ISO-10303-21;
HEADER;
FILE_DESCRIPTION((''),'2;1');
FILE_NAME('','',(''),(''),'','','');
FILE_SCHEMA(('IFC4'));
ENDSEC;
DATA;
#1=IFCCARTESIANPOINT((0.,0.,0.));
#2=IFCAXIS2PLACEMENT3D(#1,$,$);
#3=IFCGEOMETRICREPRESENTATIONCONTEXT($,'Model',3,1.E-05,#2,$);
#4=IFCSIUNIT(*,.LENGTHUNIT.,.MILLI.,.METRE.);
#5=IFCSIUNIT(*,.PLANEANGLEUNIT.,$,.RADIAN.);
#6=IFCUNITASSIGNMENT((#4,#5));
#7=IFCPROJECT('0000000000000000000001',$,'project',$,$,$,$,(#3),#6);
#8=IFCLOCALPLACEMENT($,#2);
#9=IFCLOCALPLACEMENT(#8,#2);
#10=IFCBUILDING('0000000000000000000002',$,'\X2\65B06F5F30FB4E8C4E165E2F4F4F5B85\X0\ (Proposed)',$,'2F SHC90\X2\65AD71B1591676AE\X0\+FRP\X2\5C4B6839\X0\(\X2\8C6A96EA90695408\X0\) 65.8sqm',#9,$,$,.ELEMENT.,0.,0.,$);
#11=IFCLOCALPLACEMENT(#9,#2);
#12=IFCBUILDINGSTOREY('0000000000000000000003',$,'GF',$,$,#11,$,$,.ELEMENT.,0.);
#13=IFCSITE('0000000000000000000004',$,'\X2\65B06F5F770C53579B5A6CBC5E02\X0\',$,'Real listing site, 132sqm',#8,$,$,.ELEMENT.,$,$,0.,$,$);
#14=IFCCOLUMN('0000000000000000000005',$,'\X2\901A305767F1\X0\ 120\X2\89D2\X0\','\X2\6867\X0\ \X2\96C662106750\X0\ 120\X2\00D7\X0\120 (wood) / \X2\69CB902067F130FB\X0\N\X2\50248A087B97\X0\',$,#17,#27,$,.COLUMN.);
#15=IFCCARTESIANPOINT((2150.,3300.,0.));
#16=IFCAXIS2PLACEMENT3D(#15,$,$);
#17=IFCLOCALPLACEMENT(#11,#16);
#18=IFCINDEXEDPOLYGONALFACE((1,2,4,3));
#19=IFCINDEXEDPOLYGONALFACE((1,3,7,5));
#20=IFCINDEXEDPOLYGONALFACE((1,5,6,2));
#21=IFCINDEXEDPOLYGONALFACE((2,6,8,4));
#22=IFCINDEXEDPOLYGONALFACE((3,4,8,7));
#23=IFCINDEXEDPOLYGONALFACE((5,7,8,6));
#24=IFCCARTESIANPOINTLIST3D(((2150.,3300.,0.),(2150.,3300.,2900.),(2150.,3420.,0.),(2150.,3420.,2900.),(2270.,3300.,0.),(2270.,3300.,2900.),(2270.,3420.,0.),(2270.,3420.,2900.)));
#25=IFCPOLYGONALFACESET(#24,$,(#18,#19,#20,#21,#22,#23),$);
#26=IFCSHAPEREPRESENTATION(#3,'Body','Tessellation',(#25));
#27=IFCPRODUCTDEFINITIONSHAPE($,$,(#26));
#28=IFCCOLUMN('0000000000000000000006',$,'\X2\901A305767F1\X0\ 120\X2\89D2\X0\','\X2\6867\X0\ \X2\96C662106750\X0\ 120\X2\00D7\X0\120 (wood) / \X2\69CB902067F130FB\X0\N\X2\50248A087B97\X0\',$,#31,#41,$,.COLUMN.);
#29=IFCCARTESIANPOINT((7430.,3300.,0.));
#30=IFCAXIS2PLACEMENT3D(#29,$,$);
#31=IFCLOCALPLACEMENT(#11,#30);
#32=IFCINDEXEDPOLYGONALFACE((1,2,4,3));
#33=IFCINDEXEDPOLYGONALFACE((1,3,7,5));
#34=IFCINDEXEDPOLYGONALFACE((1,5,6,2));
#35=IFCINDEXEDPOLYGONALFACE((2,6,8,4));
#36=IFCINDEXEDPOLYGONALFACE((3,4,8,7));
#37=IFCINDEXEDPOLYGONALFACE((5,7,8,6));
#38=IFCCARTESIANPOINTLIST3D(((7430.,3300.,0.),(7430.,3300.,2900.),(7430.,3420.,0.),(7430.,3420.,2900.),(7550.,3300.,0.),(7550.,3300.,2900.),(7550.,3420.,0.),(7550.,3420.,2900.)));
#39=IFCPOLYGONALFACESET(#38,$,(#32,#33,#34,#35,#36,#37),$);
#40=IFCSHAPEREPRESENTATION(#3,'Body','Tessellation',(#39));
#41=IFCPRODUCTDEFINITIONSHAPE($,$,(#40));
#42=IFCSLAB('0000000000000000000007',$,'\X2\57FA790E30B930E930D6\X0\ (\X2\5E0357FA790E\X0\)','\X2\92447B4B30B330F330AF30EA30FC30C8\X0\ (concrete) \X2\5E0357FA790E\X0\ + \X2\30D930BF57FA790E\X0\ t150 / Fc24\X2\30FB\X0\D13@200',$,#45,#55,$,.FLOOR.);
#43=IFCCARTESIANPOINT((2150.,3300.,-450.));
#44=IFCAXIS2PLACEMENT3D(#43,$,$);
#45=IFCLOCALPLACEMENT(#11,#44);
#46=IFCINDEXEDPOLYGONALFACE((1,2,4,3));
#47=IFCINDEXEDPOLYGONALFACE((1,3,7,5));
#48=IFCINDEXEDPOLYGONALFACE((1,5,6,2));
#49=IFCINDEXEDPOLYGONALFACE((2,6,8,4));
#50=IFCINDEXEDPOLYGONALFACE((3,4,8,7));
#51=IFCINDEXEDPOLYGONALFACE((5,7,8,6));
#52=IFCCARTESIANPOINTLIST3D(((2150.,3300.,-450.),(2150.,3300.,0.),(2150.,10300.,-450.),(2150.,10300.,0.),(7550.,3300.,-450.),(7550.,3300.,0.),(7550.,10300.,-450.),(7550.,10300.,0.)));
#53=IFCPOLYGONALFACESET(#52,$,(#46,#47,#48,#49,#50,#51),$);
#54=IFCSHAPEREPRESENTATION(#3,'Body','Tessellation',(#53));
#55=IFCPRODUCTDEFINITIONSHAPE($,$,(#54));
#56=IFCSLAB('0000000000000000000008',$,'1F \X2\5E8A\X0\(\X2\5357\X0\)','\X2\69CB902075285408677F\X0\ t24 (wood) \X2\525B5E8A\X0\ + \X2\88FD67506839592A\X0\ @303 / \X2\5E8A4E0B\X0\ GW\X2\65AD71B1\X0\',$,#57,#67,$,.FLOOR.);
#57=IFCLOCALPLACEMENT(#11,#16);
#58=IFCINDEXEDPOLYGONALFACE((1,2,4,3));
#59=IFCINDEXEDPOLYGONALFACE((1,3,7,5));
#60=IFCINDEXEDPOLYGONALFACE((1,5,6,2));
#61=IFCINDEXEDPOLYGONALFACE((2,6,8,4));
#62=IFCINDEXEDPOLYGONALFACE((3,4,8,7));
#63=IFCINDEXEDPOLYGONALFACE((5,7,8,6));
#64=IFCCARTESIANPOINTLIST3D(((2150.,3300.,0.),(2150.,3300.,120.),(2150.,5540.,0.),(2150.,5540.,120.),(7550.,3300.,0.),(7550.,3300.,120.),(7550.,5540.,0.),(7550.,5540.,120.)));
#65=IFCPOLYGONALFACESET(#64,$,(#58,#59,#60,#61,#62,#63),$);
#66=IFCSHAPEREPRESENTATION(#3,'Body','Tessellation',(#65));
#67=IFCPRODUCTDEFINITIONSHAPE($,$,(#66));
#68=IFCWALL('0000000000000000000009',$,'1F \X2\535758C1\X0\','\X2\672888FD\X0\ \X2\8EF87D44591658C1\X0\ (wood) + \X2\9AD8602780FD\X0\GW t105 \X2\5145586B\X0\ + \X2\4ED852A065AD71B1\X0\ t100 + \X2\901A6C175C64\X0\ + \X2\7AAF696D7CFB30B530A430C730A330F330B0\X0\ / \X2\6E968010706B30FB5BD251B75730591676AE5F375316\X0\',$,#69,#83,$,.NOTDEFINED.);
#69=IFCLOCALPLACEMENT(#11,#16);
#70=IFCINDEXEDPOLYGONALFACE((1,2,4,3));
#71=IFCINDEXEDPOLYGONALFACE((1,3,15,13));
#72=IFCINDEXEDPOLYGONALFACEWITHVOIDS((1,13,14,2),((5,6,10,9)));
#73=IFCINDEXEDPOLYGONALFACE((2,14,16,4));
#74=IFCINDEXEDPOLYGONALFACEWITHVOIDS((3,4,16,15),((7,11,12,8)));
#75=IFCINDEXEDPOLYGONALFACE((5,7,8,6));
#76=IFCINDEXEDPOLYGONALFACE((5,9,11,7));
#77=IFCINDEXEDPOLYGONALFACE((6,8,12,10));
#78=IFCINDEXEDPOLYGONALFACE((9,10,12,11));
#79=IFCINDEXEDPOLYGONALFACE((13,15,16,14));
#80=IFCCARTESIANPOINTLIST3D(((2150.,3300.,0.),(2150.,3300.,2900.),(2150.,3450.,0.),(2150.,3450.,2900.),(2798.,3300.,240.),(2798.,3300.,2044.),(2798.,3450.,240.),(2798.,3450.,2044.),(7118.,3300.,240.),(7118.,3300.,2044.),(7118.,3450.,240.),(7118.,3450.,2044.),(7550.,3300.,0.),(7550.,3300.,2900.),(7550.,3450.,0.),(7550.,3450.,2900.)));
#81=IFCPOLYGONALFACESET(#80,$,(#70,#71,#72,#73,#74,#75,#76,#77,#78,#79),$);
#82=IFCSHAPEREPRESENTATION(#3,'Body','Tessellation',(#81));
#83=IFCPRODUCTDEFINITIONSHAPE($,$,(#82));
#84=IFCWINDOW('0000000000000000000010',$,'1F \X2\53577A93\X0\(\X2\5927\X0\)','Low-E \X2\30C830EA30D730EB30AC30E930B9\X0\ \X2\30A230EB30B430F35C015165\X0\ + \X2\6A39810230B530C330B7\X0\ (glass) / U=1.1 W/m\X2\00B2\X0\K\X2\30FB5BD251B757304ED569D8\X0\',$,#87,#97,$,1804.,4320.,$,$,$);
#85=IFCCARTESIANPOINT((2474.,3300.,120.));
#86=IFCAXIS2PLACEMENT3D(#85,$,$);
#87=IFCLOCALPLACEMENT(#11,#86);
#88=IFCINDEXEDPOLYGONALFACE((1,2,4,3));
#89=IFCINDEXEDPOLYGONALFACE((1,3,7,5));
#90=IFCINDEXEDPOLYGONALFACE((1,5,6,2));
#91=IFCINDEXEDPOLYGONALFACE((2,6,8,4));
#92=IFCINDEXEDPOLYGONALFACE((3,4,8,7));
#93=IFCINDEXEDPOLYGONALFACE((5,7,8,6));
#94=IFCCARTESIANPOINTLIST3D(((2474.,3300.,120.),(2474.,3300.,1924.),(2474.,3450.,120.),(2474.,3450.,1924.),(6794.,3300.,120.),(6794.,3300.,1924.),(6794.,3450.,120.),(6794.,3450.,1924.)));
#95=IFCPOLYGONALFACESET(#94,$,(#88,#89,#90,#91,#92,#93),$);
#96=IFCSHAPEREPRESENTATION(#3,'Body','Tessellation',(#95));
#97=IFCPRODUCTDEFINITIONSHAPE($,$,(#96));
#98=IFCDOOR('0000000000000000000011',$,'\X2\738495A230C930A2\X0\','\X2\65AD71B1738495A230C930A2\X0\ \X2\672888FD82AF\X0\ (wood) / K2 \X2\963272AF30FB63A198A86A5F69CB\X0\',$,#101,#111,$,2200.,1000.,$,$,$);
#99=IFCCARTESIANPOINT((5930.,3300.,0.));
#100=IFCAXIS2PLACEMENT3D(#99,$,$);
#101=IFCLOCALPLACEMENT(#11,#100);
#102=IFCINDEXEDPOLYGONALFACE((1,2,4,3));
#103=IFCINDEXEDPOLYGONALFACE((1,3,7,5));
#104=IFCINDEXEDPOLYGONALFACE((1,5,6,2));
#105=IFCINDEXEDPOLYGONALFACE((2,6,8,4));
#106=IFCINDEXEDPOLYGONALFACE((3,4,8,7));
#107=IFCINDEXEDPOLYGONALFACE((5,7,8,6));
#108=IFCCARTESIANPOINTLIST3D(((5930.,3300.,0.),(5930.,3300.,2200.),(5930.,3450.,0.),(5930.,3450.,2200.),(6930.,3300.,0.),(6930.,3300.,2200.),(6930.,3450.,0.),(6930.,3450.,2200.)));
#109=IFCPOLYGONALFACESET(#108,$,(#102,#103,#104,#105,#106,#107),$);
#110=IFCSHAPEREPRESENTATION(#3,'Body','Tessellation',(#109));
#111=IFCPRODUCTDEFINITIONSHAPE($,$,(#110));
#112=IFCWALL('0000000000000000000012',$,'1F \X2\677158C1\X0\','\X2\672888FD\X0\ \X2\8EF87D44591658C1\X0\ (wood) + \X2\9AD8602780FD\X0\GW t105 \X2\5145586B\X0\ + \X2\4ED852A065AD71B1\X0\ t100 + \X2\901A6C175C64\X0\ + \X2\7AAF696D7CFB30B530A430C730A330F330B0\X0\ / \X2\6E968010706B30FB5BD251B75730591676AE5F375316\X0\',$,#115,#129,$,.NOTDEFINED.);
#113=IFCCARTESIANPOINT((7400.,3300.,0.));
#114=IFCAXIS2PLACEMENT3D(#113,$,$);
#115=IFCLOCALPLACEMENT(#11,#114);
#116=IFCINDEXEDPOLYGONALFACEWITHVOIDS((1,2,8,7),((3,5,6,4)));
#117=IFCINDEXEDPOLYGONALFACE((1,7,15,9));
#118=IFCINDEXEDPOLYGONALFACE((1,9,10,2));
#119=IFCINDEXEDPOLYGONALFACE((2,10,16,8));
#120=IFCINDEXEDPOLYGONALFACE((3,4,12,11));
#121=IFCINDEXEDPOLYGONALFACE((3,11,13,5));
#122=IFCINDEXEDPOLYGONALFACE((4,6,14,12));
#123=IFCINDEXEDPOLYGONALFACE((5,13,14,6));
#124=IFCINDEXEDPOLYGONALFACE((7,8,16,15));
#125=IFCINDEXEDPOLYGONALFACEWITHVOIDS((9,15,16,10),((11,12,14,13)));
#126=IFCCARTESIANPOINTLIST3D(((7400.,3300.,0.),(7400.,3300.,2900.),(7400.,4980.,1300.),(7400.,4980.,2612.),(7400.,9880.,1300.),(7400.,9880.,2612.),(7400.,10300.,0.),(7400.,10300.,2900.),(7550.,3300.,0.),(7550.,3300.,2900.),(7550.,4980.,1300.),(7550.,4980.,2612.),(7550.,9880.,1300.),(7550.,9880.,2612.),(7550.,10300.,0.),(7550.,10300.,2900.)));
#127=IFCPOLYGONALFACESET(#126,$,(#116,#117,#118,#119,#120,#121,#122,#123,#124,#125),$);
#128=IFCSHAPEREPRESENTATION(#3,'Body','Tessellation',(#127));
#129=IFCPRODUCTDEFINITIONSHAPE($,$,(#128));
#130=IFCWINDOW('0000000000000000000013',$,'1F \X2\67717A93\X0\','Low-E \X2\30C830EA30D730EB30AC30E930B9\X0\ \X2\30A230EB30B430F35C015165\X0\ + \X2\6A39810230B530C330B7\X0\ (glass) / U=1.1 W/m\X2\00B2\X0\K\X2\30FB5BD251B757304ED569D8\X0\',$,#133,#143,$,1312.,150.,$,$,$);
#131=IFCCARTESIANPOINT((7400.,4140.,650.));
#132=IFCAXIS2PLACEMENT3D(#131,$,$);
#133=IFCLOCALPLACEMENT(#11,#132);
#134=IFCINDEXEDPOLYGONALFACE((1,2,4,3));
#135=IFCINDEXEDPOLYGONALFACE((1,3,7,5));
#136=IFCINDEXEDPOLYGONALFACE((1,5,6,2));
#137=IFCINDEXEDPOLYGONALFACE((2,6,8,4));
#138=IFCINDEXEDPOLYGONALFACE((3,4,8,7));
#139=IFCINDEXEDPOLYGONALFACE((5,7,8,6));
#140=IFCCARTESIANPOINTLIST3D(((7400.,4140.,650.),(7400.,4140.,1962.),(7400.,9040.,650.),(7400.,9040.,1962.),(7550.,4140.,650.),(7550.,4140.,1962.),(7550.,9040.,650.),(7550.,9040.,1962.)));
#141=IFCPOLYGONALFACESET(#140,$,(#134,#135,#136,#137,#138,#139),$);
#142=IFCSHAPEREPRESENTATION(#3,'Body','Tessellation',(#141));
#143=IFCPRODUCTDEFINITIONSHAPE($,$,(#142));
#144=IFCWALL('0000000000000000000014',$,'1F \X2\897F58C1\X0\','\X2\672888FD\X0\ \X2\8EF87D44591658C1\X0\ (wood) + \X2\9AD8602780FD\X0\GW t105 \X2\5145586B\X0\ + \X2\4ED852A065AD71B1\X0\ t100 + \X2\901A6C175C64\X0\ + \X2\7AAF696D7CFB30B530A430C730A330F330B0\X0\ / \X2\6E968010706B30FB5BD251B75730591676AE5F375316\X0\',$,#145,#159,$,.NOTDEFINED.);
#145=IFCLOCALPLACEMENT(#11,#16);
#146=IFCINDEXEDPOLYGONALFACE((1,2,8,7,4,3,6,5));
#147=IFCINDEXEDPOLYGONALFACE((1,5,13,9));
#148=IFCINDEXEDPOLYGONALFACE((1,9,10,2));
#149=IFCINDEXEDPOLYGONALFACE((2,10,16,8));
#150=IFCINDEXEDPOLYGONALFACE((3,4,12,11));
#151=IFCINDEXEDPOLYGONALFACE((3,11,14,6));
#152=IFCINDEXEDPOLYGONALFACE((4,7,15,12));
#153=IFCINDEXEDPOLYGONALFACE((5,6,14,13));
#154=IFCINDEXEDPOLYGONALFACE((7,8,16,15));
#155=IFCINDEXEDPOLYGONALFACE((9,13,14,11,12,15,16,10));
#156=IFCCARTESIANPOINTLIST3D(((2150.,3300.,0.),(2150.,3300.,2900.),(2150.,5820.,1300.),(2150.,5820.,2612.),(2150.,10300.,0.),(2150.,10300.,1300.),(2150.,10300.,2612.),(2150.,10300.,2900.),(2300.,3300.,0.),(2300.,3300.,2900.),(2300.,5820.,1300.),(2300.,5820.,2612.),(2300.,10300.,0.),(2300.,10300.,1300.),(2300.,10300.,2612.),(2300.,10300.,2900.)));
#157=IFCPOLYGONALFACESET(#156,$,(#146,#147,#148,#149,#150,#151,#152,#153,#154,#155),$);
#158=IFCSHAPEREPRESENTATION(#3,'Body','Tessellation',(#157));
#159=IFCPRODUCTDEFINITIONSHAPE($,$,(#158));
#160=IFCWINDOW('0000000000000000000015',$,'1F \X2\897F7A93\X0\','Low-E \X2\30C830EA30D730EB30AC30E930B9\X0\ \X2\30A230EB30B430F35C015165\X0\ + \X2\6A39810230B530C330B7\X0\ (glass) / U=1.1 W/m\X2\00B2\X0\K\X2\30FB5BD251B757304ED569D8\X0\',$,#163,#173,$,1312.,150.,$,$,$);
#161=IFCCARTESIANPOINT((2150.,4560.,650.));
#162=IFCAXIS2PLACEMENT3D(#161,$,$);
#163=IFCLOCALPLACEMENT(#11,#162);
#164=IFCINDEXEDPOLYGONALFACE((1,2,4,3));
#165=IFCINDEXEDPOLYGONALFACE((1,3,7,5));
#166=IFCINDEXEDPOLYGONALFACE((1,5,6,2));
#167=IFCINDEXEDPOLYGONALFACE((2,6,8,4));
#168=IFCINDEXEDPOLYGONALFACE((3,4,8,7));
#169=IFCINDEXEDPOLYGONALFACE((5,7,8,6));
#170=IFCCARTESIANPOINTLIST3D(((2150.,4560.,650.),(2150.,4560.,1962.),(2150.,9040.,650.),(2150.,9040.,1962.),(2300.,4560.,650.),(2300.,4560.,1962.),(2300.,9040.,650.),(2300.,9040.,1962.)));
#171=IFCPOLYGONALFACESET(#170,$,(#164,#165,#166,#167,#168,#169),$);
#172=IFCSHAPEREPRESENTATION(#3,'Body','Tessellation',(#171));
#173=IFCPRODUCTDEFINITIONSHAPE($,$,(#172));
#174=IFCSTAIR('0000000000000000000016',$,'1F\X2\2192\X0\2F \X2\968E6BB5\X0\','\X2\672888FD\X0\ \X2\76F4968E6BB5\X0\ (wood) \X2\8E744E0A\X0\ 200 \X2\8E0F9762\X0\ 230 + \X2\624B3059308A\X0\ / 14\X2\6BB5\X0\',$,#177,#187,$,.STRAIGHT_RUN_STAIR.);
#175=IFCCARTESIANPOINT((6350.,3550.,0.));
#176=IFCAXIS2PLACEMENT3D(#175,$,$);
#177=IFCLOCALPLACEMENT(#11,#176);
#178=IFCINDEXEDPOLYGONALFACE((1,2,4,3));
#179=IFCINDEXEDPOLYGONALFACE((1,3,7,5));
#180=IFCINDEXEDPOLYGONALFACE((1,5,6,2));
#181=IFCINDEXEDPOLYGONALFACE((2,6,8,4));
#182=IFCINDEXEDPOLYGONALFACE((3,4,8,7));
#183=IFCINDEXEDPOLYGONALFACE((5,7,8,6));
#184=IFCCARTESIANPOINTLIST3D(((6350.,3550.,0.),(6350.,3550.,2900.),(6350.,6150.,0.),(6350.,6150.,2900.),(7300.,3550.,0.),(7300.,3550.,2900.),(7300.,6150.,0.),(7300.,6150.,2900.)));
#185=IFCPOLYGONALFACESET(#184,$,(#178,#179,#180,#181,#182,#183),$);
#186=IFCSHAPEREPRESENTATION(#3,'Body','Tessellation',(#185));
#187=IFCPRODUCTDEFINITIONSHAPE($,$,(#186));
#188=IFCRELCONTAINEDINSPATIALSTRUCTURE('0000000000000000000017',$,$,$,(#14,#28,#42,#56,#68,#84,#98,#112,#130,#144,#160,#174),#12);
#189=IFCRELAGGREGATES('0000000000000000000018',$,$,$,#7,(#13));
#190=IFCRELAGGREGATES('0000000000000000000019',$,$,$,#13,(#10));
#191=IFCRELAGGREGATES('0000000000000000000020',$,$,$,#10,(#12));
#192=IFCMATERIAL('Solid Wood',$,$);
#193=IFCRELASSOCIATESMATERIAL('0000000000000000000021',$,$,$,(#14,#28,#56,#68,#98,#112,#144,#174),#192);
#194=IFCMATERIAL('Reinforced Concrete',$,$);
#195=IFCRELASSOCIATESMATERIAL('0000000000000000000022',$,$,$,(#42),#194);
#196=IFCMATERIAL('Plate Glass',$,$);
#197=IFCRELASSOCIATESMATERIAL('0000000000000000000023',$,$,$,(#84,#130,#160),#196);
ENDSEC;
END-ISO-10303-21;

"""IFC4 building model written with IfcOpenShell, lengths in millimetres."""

from ifc_helpers import new_model, si_unit, frame, frame_2d, origin, place, context, project, spatial, rectangle, extrude, material, element, fill, save


model = new_model("IFC4")

# Units and contexts
model_context = context("Model", 3, precision=1e-05, world=origin())
ifc_project = project(units=[si_unit("LENGTHUNIT", "METRE", prefix="MILLI"), si_unit("PLANEANGLEUNIT", "RADIAN")], contexts=[model_context])

# Site, building, storey
site_placement = place(None, origin())
site = spatial("IfcSite", under=ifc_project, at=site_placement, Name="新潟県南魚沼市", ObjectType="Real listing site, 132sqm", CompositionType="ELEMENT", RefElevation=0.0)
building_placement = place(site_placement, origin())
building = spatial("IfcBuilding", under=site, at=building_placement, Name="新潟・二世帯住宅 (Proposed)", ObjectType="2F SHC90断熱外皮+FRP屋根(豪雪適合) 65.8sqm", CompositionType="ELEMENT", ElevationOfRefHeight=0.0, ElevationOfTerrain=0.0)
storey_placement = place(building_placement, origin())
storey = spatial("IfcBuildingStorey", under=building, at=storey_placement, Name="GF", CompositionType="ELEMENT", Elevation=0.0)

# Columns
ifc_material_1 = material(Name="Solid Wood")
column_1_placement = place(storey_placement, frame((2150.0, 3300.0, 0.0)))
element("IfcColumn", 1, at=column_1_placement, inside=storey, material=ifc_material_1, Name="通し柱 120角", Description="桧 集成材 120×120 (wood) / 構造柱・N値計算", PredefinedType="COLUMN", context=model_context, shape_type="SweptSolid", body=[
    extrude(rectangle(XDim=120.0, YDim=120.0, at=frame_2d((60.0, 60.0))), frame((2150.0, 3300.0, 0.0)), (0.0, 0.0, 1.0), 2900.0),
])
column_2_placement = place(storey_placement, frame((7430.0, 3300.0, 0.0)))
element("IfcColumn", 2, at=column_2_placement, inside=storey, material=ifc_material_1, Name="通し柱 120角", Description="桧 集成材 120×120 (wood) / 構造柱・N値計算", PredefinedType="COLUMN", context=model_context, shape_type="SweptSolid", body=[
    extrude(rectangle(XDim=120.0, YDim=120.0, at=frame_2d((60.0, 60.0))), frame((7430.0, 3300.0, 0.0)), (0.0, 0.0, 1.0), 2900.0),
])

# Slabs
ifc_material_2 = material(Name="Reinforced Concrete")
slab_1_placement = place(storey_placement, frame((2150.0, 3300.0, -450.0)))
element("IfcSlab", 3, at=slab_1_placement, inside=storey, material=ifc_material_2, Name="基礎スラブ (布基礎)", Description="鉄筋コンクリート (concrete) 布基礎 + ベタ基礎 t150 / Fc24・D13@200", PredefinedType="FLOOR", context=model_context, shape_type="SweptSolid", body=[
    extrude(rectangle(XDim=5400.0, YDim=7000.0, at=frame_2d((2700.0, 3500.0))), frame((2150.0, 3300.0, -450.0)), (0.0, 0.0, 1.0), 450.0),
])
slab_2_placement = place(storey_placement, frame((2150.0, 3300.0, 0.0)))
element("IfcSlab", 4, at=slab_2_placement, inside=storey, material=ifc_material_1, Name="1F 床(南)", Description="構造用合板 t24 (wood) 剛床 + 製材根太 @303 / 床下 GW断熱", PredefinedType="FLOOR", context=model_context, shape_type="SweptSolid", body=[
    extrude(rectangle(XDim=5400.0, YDim=2240.0, at=frame_2d((2700.0, 1120.0))), frame((2150.0, 3300.0, 0.0)), (0.0, 0.0, 1.0), 120.0),
])

# Wall, openings, window, door
wall_1_placement = place(storey_placement, frame((2150.0, 3300.0, 0.0)))
wall_1 = element("IfcWall", 5, at=wall_1_placement, inside=storey, material=ifc_material_1, Name="1F 南壁", Description="木製 軸組外壁 (wood) + 高性能GW t105 充填 + 付加断熱 t100 + 通気層 + 窯業系サイディング / 準耐火・寒冷地外皮強化", PredefinedType="NOTDEFINED", context=model_context, shape_type="SweptSolid", body=[
    extrude(rectangle(XDim=5400.0, YDim=150.0, at=frame_2d((2700.0, 75.0))), frame((2150.0, 3300.0, 0.0)), (0.0, 0.0, 1.0), 2900.0),
])
opening_1_placement = place(storey_placement, frame((2474.0, 3300.0, 120.0)))
opening_1 = element("IfcOpeningElement", 6, at=opening_1_placement, cuts=wall_1, PredefinedType="NOTDEFINED", context=model_context, shape_type="SweptSolid", body=[
    extrude(rectangle(XDim=4320.0, YDim=150.0, at=frame_2d((2160.0, 75.0))), frame((2474.0, 3300.0, 120.0)), (0.0, 0.0, 1.0), 1804.0),
])
opening_2_placement = place(storey_placement, frame((5930.0, 3300.0, 0.0)))
opening_2 = element("IfcOpeningElement", 7, at=opening_2_placement, cuts=wall_1, PredefinedType="NOTDEFINED", context=model_context, shape_type="SweptSolid", body=[
    extrude(rectangle(XDim=1000.0, YDim=150.0, at=frame_2d((500.0, 75.0))), frame((5930.0, 3300.0, 0.0)), (0.0, 0.0, 1.0), 2200.0),
])
ifc_material_3 = material(Name="Plate Glass")
window_1_placement = place(storey_placement, frame((2474.0, 3300.0, 120.0)))
window_1 = element("IfcWindow", 8, at=window_1_placement, inside=storey, material=ifc_material_3, Name="1F 南窓(大)", Description="Low-E トリプルガラス アルゴン封入 + 樹脂サッシ (glass) / U=1.1 W/m²K・寒冷地仕様", OverallHeight=1804.0, OverallWidth=4320.0, context=model_context, shape_type="SweptSolid", body=[
    extrude(rectangle(XDim=4320.0, YDim=150.0, at=frame_2d((2160.0, 75.0))), frame((2474.0, 3300.0, 120.0)), (0.0, 0.0, 1.0), 1804.0),
])
fill(opening_1, window_1)
door_placement = place(storey_placement, frame((5930.0, 3300.0, 0.0)))
door = element("IfcDoor", 9, at=door_placement, inside=storey, material=ifc_material_1, Name="玄関ドア", Description="断熱玄関ドア 木製芯 (wood) / K2 防犯・採風機構", OverallHeight=2200.0, OverallWidth=1000.0, context=model_context, shape_type="SweptSolid", body=[
    extrude(rectangle(XDim=1000.0, YDim=150.0, at=frame_2d((500.0, 75.0))), frame((5930.0, 3300.0, 0.0)), (0.0, 0.0, 1.0), 2200.0),
])
fill(opening_2, door)

# Walls, openings, windows
wall_2_placement = place(storey_placement, frame((7400.0, 3300.0, 0.0)))
wall_2 = element("IfcWall", 10, at=wall_2_placement, inside=storey, material=ifc_material_1, Name="1F 東壁", Description="木製 軸組外壁 (wood) + 高性能GW t105 充填 + 付加断熱 t100 + 通気層 + 窯業系サイディング / 準耐火・寒冷地外皮強化", PredefinedType="NOTDEFINED", context=model_context, shape_type="SweptSolid", body=[
    extrude(rectangle(XDim=150.0, YDim=7000.0, at=frame_2d((75.0, 3500.0))), frame((7400.0, 3300.0, 0.0)), (0.0, 0.0, 1.0), 2900.0),
])
opening_3_placement = place(storey_placement, frame((7400.0, 4140.0, 650.0)))
opening_3 = element("IfcOpeningElement", 11, at=opening_3_placement, cuts=wall_2, PredefinedType="NOTDEFINED", context=model_context, shape_type="SweptSolid", body=[
    extrude(rectangle(XDim=150.0, YDim=4900.0, at=frame_2d((75.0, 2450.0))), frame((7400.0, 4140.0, 650.0)), (0.0, 0.0, 1.0), 1312.0),
])
window_2_placement = place(storey_placement, frame((7400.0, 4140.0, 650.0)))
window_2 = element("IfcWindow", 12, at=window_2_placement, inside=storey, material=ifc_material_3, Name="1F 東窓", Description="Low-E トリプルガラス アルゴン封入 + 樹脂サッシ (glass) / U=1.1 W/m²K・寒冷地仕様", OverallHeight=1312.0, OverallWidth=150.0, context=model_context, shape_type="SweptSolid", body=[
    extrude(rectangle(XDim=150.0, YDim=4900.0, at=frame_2d((75.0, 2450.0))), frame((7400.0, 4140.0, 650.0)), (0.0, 0.0, 1.0), 1312.0),
])
fill(opening_3, window_2)
wall_3_placement = place(storey_placement, frame((2150.0, 3300.0, 0.0)))
wall_3 = element("IfcWall", 13, at=wall_3_placement, inside=storey, material=ifc_material_1, Name="1F 西壁", Description="木製 軸組外壁 (wood) + 高性能GW t105 充填 + 付加断熱 t100 + 通気層 + 窯業系サイディング / 準耐火・寒冷地外皮強化", PredefinedType="NOTDEFINED", context=model_context, shape_type="SweptSolid", body=[
    extrude(rectangle(XDim=150.0, YDim=7000.0, at=frame_2d((75.0, 3500.0))), frame((2150.0, 3300.0, 0.0)), (0.0, 0.0, 1.0), 2900.0),
])
opening_4_placement = place(storey_placement, frame((2150.0, 4560.0, 650.0)))
opening_4 = element("IfcOpeningElement", 14, at=opening_4_placement, cuts=wall_3, PredefinedType="NOTDEFINED", context=model_context, shape_type="SweptSolid", body=[
    extrude(rectangle(XDim=150.0, YDim=4480.0, at=frame_2d((75.0, 2240.0))), frame((2150.0, 4560.0, 650.0)), (0.0, 0.0, 1.0), 1312.0),
])
window_3_placement = place(storey_placement, frame((2150.0, 4560.0, 650.0)))
window_3 = element("IfcWindow", 15, at=window_3_placement, inside=storey, material=ifc_material_3, Name="1F 西窓", Description="Low-E トリプルガラス アルゴン封入 + 樹脂サッシ (glass) / U=1.1 W/m²K・寒冷地仕様", OverallHeight=1312.0, OverallWidth=150.0, context=model_context, shape_type="SweptSolid", body=[
    extrude(rectangle(XDim=150.0, YDim=4480.0, at=frame_2d((75.0, 2240.0))), frame((2150.0, 4560.0, 650.0)), (0.0, 0.0, 1.0), 1312.0),
])
fill(opening_4, window_3)

# Stair
stair_placement = place(storey_placement, frame((6350.0, 3550.0, 0.0)))
element("IfcStair", 16, at=stair_placement, inside=storey, material=ifc_material_1, Name="1F→2F 階段", Description="木製 直階段 (wood) 蹴上 200 踏面 230 + 手すり / 14段", PredefinedType="STRAIGHT_RUN_STAIR", context=model_context, shape_type="SweptSolid", body=[
    extrude(rectangle(XDim=950.0, YDim=2600.0, at=frame_2d((475.0, 1300.0))), frame((6350.0, 3550.0, 0.0)), (0.0, 0.0, 1.0), 2900.0),
])

save(model, "model.ifc")
